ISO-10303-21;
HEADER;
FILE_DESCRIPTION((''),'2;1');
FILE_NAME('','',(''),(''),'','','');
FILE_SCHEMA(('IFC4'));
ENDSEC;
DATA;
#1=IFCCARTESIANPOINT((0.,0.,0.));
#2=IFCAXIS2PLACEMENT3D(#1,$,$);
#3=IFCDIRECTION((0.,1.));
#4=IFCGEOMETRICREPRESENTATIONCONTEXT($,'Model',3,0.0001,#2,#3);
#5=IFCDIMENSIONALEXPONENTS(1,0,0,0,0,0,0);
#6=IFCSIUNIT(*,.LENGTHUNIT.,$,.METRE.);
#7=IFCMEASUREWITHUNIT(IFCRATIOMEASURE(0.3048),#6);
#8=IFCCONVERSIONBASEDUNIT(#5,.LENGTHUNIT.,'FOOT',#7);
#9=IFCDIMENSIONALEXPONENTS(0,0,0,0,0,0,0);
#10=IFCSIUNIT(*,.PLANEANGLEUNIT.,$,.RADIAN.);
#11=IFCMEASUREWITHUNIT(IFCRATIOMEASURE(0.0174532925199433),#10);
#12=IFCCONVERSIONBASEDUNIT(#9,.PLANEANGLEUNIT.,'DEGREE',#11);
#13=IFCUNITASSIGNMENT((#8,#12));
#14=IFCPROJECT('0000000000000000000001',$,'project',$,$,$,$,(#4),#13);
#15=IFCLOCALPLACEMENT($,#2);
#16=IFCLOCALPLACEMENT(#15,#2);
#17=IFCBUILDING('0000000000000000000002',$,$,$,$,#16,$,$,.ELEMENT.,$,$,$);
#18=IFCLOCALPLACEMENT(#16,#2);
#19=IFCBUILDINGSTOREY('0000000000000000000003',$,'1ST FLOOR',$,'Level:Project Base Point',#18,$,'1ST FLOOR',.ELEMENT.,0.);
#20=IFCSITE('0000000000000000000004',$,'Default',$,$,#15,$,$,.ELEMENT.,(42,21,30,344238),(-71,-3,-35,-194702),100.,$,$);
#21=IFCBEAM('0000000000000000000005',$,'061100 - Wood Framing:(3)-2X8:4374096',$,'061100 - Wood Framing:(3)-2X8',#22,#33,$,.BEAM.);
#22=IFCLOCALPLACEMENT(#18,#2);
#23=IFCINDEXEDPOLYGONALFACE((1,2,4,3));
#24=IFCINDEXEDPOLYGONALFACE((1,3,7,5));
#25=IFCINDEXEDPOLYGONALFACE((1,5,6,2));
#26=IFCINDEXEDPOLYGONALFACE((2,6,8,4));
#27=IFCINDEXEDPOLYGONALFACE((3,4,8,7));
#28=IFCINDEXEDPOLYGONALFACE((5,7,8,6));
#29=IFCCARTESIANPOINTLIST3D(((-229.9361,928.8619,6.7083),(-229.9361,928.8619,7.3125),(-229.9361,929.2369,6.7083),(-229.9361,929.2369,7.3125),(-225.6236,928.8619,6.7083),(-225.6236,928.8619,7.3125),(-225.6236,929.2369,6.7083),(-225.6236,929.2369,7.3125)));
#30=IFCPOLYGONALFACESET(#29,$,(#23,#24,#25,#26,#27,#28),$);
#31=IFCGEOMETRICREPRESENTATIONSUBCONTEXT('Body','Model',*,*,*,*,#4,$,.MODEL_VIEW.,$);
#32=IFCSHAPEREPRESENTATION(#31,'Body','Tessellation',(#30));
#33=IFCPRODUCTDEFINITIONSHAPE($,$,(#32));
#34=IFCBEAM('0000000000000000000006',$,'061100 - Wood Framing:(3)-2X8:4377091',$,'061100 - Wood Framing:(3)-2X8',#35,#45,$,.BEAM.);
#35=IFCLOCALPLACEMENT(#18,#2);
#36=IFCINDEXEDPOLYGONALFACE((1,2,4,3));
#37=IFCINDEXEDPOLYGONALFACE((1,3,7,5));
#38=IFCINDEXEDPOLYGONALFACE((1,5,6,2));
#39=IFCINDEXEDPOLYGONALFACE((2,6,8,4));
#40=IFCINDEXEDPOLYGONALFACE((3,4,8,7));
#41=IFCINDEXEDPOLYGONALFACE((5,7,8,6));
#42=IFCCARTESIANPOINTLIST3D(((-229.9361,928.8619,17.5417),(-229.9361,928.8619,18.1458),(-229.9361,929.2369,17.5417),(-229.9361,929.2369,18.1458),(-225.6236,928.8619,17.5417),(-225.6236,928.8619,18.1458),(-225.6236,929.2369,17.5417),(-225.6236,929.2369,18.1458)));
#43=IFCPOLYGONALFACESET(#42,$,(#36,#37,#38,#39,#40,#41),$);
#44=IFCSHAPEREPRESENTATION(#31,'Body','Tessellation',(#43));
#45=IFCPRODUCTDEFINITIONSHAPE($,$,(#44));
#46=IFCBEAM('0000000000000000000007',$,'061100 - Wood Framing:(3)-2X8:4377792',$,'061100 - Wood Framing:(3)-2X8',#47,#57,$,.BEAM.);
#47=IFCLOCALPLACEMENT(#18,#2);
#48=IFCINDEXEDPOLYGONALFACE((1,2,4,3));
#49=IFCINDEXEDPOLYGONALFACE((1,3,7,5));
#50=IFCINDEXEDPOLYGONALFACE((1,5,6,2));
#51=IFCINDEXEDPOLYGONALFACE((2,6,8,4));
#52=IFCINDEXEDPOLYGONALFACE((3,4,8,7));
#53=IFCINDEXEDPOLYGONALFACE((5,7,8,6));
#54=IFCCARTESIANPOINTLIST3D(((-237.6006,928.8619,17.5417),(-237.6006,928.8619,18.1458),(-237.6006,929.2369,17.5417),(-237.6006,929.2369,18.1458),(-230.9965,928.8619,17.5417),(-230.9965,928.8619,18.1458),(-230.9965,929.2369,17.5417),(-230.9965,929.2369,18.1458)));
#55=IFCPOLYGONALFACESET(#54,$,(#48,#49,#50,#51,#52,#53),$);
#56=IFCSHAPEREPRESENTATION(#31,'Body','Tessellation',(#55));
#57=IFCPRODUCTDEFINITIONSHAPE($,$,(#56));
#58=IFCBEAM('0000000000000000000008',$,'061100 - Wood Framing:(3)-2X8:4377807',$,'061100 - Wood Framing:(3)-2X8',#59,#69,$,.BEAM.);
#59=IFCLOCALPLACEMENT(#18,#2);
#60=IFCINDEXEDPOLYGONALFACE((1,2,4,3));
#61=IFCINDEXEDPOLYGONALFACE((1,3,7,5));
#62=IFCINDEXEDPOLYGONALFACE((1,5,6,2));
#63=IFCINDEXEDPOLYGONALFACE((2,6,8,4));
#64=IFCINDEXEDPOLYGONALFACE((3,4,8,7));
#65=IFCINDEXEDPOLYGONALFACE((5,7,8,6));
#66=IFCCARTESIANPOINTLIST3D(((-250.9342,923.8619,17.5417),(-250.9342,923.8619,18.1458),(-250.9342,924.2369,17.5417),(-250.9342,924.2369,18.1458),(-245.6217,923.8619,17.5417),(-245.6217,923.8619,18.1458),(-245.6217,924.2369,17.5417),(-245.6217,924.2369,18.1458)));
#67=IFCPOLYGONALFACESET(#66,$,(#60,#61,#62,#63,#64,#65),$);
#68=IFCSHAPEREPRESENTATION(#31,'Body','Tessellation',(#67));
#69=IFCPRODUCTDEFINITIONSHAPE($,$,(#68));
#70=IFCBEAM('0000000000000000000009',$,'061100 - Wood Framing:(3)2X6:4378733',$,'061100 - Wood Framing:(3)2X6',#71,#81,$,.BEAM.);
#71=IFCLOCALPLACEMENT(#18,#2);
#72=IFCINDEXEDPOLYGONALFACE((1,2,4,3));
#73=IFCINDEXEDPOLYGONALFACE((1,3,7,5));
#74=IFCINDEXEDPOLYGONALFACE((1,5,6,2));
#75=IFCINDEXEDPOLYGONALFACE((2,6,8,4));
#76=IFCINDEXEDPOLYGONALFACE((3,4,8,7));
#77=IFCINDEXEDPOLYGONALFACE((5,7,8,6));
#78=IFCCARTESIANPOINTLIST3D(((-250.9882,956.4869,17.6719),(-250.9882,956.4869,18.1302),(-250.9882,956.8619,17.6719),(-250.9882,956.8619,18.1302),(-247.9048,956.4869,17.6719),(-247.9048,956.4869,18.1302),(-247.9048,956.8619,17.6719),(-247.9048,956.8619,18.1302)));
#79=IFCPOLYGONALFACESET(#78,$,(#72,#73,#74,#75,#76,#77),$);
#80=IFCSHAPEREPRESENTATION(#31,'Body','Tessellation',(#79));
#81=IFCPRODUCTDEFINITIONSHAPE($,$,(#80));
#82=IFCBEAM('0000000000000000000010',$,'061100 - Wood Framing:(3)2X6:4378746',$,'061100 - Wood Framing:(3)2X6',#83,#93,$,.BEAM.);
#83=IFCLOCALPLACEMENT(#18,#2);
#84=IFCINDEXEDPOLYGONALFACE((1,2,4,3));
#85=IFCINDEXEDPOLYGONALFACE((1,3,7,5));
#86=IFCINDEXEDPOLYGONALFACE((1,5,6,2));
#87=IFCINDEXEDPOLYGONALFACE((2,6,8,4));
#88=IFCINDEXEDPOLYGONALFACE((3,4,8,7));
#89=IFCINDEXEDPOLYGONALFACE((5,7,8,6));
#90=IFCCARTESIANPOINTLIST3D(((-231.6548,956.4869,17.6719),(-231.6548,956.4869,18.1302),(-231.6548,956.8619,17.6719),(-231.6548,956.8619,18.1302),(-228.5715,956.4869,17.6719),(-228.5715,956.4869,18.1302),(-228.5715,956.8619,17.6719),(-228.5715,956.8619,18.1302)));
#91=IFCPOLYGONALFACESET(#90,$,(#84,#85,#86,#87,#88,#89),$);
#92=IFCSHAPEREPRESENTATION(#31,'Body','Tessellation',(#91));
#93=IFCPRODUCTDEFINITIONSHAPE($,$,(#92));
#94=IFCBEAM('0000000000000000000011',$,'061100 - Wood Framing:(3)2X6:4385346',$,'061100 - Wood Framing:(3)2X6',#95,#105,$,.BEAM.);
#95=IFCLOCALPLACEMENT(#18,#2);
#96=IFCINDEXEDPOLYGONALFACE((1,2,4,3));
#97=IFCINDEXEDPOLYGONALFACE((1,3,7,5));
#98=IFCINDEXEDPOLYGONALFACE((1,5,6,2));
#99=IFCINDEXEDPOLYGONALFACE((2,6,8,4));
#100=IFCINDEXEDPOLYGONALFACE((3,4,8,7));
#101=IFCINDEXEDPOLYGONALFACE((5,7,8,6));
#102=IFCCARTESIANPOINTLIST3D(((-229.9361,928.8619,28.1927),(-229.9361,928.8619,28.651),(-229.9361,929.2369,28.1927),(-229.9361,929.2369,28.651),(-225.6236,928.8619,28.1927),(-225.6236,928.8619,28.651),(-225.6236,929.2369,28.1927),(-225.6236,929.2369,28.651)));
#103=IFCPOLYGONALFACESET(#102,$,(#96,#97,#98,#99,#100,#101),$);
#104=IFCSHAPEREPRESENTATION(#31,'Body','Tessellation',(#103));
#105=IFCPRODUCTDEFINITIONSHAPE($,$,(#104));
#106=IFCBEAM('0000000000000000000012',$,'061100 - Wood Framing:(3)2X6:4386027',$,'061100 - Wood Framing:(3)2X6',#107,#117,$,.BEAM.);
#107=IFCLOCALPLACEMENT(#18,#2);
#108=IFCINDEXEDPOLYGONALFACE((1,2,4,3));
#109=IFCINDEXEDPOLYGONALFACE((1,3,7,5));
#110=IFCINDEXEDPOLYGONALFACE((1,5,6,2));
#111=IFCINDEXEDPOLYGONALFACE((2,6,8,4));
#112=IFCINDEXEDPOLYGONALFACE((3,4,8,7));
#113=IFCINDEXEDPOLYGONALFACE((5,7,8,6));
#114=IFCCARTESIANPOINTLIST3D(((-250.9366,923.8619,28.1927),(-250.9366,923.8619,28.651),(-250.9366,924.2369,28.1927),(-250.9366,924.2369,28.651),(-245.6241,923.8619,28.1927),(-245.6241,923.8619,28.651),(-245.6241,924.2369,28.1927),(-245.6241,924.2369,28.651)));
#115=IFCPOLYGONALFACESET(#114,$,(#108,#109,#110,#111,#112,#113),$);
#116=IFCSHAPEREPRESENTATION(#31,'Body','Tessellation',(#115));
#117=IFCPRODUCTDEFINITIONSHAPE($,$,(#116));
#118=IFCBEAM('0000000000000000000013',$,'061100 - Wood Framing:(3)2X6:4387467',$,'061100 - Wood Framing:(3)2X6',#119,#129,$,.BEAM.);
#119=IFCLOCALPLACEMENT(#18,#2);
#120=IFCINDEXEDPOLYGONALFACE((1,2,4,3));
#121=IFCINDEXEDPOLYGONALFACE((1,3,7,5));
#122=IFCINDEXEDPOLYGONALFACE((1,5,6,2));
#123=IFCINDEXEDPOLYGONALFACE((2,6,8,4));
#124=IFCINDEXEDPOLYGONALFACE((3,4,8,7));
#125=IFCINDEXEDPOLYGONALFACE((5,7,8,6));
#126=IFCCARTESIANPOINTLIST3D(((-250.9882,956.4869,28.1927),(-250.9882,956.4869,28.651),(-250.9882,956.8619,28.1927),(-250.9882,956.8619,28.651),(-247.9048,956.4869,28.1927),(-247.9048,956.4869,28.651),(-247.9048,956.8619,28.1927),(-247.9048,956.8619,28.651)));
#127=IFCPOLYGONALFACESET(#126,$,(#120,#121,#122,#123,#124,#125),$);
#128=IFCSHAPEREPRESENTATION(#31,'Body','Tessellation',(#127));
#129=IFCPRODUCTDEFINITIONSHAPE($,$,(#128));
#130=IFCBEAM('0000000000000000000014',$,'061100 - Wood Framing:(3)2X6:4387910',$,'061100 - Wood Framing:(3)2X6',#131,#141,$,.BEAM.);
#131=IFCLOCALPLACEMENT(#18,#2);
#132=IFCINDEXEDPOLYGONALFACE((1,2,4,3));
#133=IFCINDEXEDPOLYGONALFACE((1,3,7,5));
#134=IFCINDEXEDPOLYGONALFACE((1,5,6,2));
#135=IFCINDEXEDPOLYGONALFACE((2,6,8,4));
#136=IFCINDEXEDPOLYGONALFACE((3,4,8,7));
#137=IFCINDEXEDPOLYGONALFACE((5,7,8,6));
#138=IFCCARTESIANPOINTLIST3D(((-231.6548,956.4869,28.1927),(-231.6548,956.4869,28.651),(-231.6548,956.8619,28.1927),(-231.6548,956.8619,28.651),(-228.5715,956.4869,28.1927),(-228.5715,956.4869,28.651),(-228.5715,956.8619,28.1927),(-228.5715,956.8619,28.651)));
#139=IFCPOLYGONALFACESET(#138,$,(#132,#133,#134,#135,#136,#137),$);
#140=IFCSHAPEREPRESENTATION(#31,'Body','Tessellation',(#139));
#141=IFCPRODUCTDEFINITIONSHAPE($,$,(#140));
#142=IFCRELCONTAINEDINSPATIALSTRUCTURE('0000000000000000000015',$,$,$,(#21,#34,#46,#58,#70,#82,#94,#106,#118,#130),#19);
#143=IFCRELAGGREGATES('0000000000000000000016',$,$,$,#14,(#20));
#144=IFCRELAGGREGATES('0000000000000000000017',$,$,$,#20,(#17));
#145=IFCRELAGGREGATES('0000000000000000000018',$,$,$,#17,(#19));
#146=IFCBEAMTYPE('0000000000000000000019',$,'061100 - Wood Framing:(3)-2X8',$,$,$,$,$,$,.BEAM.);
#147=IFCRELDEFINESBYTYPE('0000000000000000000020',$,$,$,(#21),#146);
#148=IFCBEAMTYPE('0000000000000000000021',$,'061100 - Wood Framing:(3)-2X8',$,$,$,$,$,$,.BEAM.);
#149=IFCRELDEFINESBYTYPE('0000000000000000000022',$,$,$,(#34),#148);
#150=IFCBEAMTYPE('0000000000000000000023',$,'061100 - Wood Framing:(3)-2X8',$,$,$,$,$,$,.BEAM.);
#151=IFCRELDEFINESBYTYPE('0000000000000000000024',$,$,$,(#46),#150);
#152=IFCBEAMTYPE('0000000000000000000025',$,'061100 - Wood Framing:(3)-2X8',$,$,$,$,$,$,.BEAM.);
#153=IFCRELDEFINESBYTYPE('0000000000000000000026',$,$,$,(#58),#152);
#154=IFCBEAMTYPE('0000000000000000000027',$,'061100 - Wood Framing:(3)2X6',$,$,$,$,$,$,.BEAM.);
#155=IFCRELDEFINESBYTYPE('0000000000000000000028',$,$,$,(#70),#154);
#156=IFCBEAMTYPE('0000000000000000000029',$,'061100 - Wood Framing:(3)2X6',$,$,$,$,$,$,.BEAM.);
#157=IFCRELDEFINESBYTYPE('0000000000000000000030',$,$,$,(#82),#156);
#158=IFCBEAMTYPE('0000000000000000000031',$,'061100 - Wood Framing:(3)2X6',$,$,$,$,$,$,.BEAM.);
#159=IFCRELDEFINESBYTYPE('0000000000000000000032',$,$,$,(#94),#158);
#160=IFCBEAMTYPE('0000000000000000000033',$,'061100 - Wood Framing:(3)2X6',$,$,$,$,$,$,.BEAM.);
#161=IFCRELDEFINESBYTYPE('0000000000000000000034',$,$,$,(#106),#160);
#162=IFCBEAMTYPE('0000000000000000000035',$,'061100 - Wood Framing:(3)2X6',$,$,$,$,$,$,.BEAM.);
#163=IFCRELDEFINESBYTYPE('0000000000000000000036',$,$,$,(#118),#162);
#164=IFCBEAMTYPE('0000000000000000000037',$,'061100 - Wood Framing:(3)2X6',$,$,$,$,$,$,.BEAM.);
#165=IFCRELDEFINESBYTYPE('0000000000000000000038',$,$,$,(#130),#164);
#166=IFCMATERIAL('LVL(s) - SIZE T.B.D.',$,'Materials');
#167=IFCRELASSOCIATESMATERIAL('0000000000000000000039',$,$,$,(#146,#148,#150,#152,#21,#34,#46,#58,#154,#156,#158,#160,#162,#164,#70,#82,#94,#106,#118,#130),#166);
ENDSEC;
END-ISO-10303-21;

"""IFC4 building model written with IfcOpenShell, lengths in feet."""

from ifc_helpers import new_model, entity, si_unit, converted_unit, direction, frame, frame_2d, origin, place, context, subcontext, project, spatial, rectangle, extrude, source, transform, mapped, material, material_profile, profile_set, profile_usage, type_object, type_shapes, element, save


model = new_model("IFC4")

# Units and contexts
model_context = context("Model", 3, precision=0.0001, world=origin(), true_north=direction((0.0, 1.0)))
body_context = subcontext(model_context, "Body", "Model", "MODEL_VIEW")
ifc_project = project(units=[converted_unit("LENGTHUNIT", "FOOT", entity("IfcRatioMeasure", 0.3048), si_unit("LENGTHUNIT", "METRE"), dimensions=[1, 0, 0, 0, 0, 0, 0]), converted_unit("PLANEANGLEUNIT", "DEGREE", entity("IfcRatioMeasure", 0.0174532925199433), si_unit("PLANEANGLEUNIT", "RADIAN"), dimensions=[0, 0, 0, 0, 0, 0, 0])], contexts=[model_context])

# Site, building, storey
site_placement = place(None, origin())
site = spatial("IfcSite", under=ifc_project, at=site_placement, Name="Default", CompositionType="ELEMENT", RefLatitude=(42, 21, 30, 344238), RefLongitude=(-71, -3, -35, -194702), RefElevation=100.0)
building_placement = place(site_placement, origin())
building = spatial("IfcBuilding", under=site, at=building_placement, CompositionType="ELEMENT")
storey_placement = place(building_placement, origin())
storey = spatial("IfcBuildingStorey", under=building, at=storey_placement, Name="1ST FLOOR", ObjectType="Level:Project Base Point", LongName="1ST FLOOR", CompositionType="ELEMENT", Elevation=0.0)

# Beams
ifc_material_1 = material(Name="LVL(s) - SIZE T.B.D.", Category="Materials")
ifc_material_profile_1 = material_profile(ifc_material_1, rectangle(XDim=0.6042, YDim=0.375, at=frame_2d((0.0, 0.0), x_axis=(1.0, 0.0))), Name="(3)-2X8")
ifc_profile_set_1 = profile_set([ifc_material_profile_1], Name="(3)-2X8")
ifc_profile_usage_1 = profile_usage(ifc_profile_set_1, cardinal=8)
beam_type_1 = type_object("IfcBeamType", Name="061100 - Wood Framing:(3)-2X8", PredefinedType="BEAM", material=ifc_profile_set_1)
shared_shape_1 = source(origin(), body_context, "Body", "SweptSolid", [
    extrude(rectangle(XDim=0.6042, YDim=0.375, at=frame_2d((0.0, 0.0), x_axis=(1.0, 0.0))), frame((-2.1737, 0.0, 0.0), z_axis=(1.0, 0.0, 0.0), x_axis=(0.0, 0.0, -1.0)), (0.0, 0.0, 1.0), 4.3125),
])
type_shapes(beam_type_1, [shared_shape_1])
beam_1_placement = place(storey_placement, frame((-227.7624, 929.0494, 7.0104)))
element("IfcBeam", 1, at=beam_1_placement, inside=storey, type_object=beam_type_1, material=ifc_profile_usage_1, Name="061100 - Wood Framing:(3)-2X8:4374096", ObjectType="061100 - Wood Framing:(3)-2X8", PredefinedType="BEAM", context=body_context, shape_type="MappedRepresentation", body=[
    mapped(shared_shape_1, transform((0.0, 0.0, 0.0), scale=1.0)),
])
ifc_profile_usage_2 = profile_usage(ifc_profile_set_1, cardinal=8)
beam_type_2 = type_object("IfcBeamType", Name="061100 - Wood Framing:(3)-2X8", PredefinedType="BEAM", material=ifc_profile_set_1)
shared_shape_2 = source(origin(), body_context, "Body", "SweptSolid", [
    extrude(rectangle(XDim=0.6042, YDim=0.375, at=frame_2d((0.0, 0.0), x_axis=(1.0, 0.0))), frame((-2.18, 0.0, 0.0), z_axis=(1.0, 0.0, 0.0), x_axis=(0.0, 0.0, -1.0)), (0.0, 0.0, 1.0), 4.3125),
])
type_shapes(beam_type_2, [shared_shape_2])
beam_2_placement = place(storey_placement, frame((-227.7561, 929.0494, 17.8438)))
element("IfcBeam", 2, at=beam_2_placement, inside=storey, type_object=beam_type_2, material=ifc_profile_usage_2, Name="061100 - Wood Framing:(3)-2X8:4377091", ObjectType="061100 - Wood Framing:(3)-2X8", PredefinedType="BEAM", context=body_context, shape_type="MappedRepresentation", body=[
    mapped(shared_shape_2, transform((0.0, 0.0, 0.0), scale=1.0)),
])
ifc_profile_usage_3 = profile_usage(ifc_profile_set_1, cardinal=8)
beam_type_3 = type_object("IfcBeamType", Name="061100 - Wood Framing:(3)-2X8", PredefinedType="BEAM", material=ifc_profile_set_1)
shared_shape_3 = source(origin(), body_context, "Body", "SweptSolid", [
    extrude(rectangle(XDim=0.6042, YDim=0.375, at=frame_2d((0.0, 0.0), x_axis=(1.0, 0.0))), frame((-3.3258, 0.0, 0.0), z_axis=(1.0, 0.0, 0.0), x_axis=(0.0, 0.0, -1.0)), (0.0, 0.0, 1.0), 6.6042),
])
type_shapes(beam_type_3, [shared_shape_3])
beam_3_placement = place(storey_placement, frame((-234.2748, 929.0494, 17.8438)))
element("IfcBeam", 3, at=beam_3_placement, inside=storey, type_object=beam_type_3, material=ifc_profile_usage_3, Name="061100 - Wood Framing:(3)-2X8:4377792", ObjectType="061100 - Wood Framing:(3)-2X8", PredefinedType="BEAM", context=body_context, shape_type="MappedRepresentation", body=[
    mapped(shared_shape_3, transform((0.0, 0.0, 0.0), scale=1.0)),
])
ifc_profile_usage_4 = profile_usage(ifc_profile_set_1, cardinal=8)
beam_type_4 = type_object("IfcBeamType", Name="061100 - Wood Framing:(3)-2X8", PredefinedType="BEAM", material=ifc_profile_set_1)
shared_shape_4 = source(origin(), body_context, "Body", "SweptSolid", [
    extrude(rectangle(XDim=0.6042, YDim=0.375, at=frame_2d((0.0, 0.0), x_axis=(1.0, 0.0))), frame((-2.68, 0.0, 0.0), z_axis=(1.0, 0.0, 0.0), x_axis=(0.0, 0.0, -1.0)), (0.0, 0.0, 1.0), 5.3125),
])
type_shapes(beam_type_4, [shared_shape_4])
beam_4_placement = place(storey_placement, frame((-248.2542, 924.0494, 17.8438)))
element("IfcBeam", 4, at=beam_4_placement, inside=storey, type_object=beam_type_4, material=ifc_profile_usage_4, Name="061100 - Wood Framing:(3)-2X8:4377807", ObjectType="061100 - Wood Framing:(3)-2X8", PredefinedType="BEAM", context=body_context, shape_type="MappedRepresentation", body=[
    mapped(shared_shape_4, transform((0.0, 0.0, 0.0), scale=1.0)),
])
ifc_material_profile_2 = material_profile(ifc_material_1, rectangle(XDim=0.4583, YDim=0.375, at=frame_2d((0.0, 0.0), x_axis=(1.0, 0.0))), Name="(3)2X6")
ifc_profile_set_2 = profile_set([ifc_material_profile_2], Name="(3)2X6")
ifc_profile_usage_5 = profile_usage(ifc_profile_set_2, cardinal=8)
beam_type_5 = type_object("IfcBeamType", Name="061100 - Wood Framing:(3)2X6", PredefinedType="BEAM", material=ifc_profile_set_2)
shared_shape_5 = source(origin(), body_context, "Body", "SweptSolid", [
    extrude(rectangle(XDim=0.4583, YDim=0.375, at=frame_2d((0.0, 0.0), x_axis=(1.0, 0.0))), frame((-1.5364, 0.0, 0.0), z_axis=(1.0, 0.0, 0.0), x_axis=(0.0, 0.0, -1.0)), (0.0, 0.0, 1.0), 3.0833),
])
type_shapes(beam_type_5, [shared_shape_5])
beam_5_placement = place(storey_placement, frame((-249.4517, 956.6744, 17.901)))
element("IfcBeam", 5, at=beam_5_placement, inside=storey, type_object=beam_type_5, material=ifc_profile_usage_5, Name="061100 - Wood Framing:(3)2X6:4378733", ObjectType="061100 - Wood Framing:(3)2X6", PredefinedType="BEAM", context=body_context, shape_type="MappedRepresentation", body=[
    mapped(shared_shape_5, transform((0.0, 0.0, 0.0), scale=1.0)),
])
ifc_profile_usage_6 = profile_usage(ifc_profile_set_2, cardinal=8)
beam_type_6 = type_object("IfcBeamType", Name="061100 - Wood Framing:(3)2X6", PredefinedType="BEAM", material=ifc_profile_set_2)
shared_shape_6 = source(origin(), body_context, "Body", "SweptSolid", [
    extrude(rectangle(XDim=0.4583, YDim=0.375, at=frame_2d((0.0, 0.0), x_axis=(1.0, 0.0))), frame((-1.5156, 0.0, 0.0), z_axis=(1.0, 0.0, 0.0), x_axis=(0.0, 0.0, -1.0)), (0.0, 0.0, 1.0), 3.0833),
])
type_shapes(beam_type_6, [shared_shape_6])
beam_6_placement = place(storey_placement, frame((-230.1392, 956.6744, 17.901)))
element("IfcBeam", 6, at=beam_6_placement, inside=storey, type_object=beam_type_6, material=ifc_profile_usage_6, Name="061100 - Wood Framing:(3)2X6:4378746", ObjectType="061100 - Wood Framing:(3)2X6", PredefinedType="BEAM", context=body_context, shape_type="MappedRepresentation", body=[
    mapped(shared_shape_6, transform((0.0, 0.0, 0.0), scale=1.0)),
])
ifc_profile_usage_7 = profile_usage(ifc_profile_set_2, cardinal=8)
beam_type_7 = type_object("IfcBeamType", Name="061100 - Wood Framing:(3)2X6", PredefinedType="BEAM", material=ifc_profile_set_2)
shared_shape_7 = source(origin(), body_context, "Body", "SweptSolid", [
    extrude(rectangle(XDim=0.4583, YDim=0.375, at=frame_2d((0.0, 0.0), x_axis=(1.0, 0.0))), frame((-2.1711, 0.0, 0.0), z_axis=(1.0, 0.0, 0.0), x_axis=(0.0, 0.0, -1.0)), (0.0, 0.0, 1.0), 4.3125),
])
type_shapes(beam_type_7, [shared_shape_7])
beam_7_placement = place(storey_placement, frame((-227.7649, 929.0494, 28.4219)))
element("IfcBeam", 7, at=beam_7_placement, inside=storey, type_object=beam_type_7, material=ifc_profile_usage_7, Name="061100 - Wood Framing:(3)2X6:4385346", ObjectType="061100 - Wood Framing:(3)2X6", PredefinedType="BEAM", context=body_context, shape_type="MappedRepresentation", body=[
    mapped(shared_shape_7, transform((0.0, 0.0, 0.0), scale=1.0)),
])
ifc_profile_usage_8 = profile_usage(ifc_profile_set_2, cardinal=8)
beam_type_8 = type_object("IfcBeamType", Name="061100 - Wood Framing:(3)2X6", PredefinedType="BEAM", material=ifc_profile_set_2)
shared_shape_8 = source(origin(), body_context, "Body", "SweptSolid", [
    extrude(rectangle(XDim=0.4583, YDim=0.375, at=frame_2d((0.0, 0.0), x_axis=(1.0, 0.0))), frame((-2.6711, 0.0, 0.0), z_axis=(1.0, 0.0, 0.0), x_axis=(0.0, 0.0, -1.0)), (0.0, 0.0, 1.0), 5.3125),
])
type_shapes(beam_type_8, [shared_shape_8])
beam_8_placement = place(storey_placement, frame((-248.2654, 924.0494, 28.4219)))
element("IfcBeam", 8, at=beam_8_placement, inside=storey, type_object=beam_type_8, material=ifc_profile_usage_8, Name="061100 - Wood Framing:(3)2X6:4386027", ObjectType="061100 - Wood Framing:(3)2X6", PredefinedType="BEAM", context=body_context, shape_type="MappedRepresentation", body=[
    mapped(shared_shape_8, transform((0.0, 0.0, 0.0), scale=1.0)),
])
ifc_profile_usage_9 = profile_usage(ifc_profile_set_2, cardinal=8)
beam_type_9 = type_object("IfcBeamType", Name="061100 - Wood Framing:(3)2X6", PredefinedType="BEAM", material=ifc_profile_set_2)
shared_shape_9 = source(origin(), body_context, "Body", "SweptSolid", [
    extrude(rectangle(XDim=0.4583, YDim=0.375, at=frame_2d((0.0, 0.0), x_axis=(1.0, 0.0))), frame((-1.5391, 0.0, 0.0), z_axis=(1.0, 0.0, 0.0), x_axis=(0.0, 0.0, -1.0)), (0.0, 0.0, 1.0), 3.0833),
])
type_shapes(beam_type_9, [shared_shape_9])
beam_9_placement = place(storey_placement, frame((-249.4491, 956.6744, 28.4219)))
element("IfcBeam", 9, at=beam_9_placement, inside=storey, type_object=beam_type_9, material=ifc_profile_usage_9, Name="061100 - Wood Framing:(3)2X6:4387467", ObjectType="061100 - Wood Framing:(3)2X6", PredefinedType="BEAM", context=body_context, shape_type="MappedRepresentation", body=[
    mapped(shared_shape_9, transform((0.0, 0.0, 0.0), scale=1.0)),
])
ifc_profile_usage_10 = profile_usage(ifc_profile_set_2, cardinal=8)
beam_type_10 = type_object("IfcBeamType", Name="061100 - Wood Framing:(3)2X6", PredefinedType="BEAM", material=ifc_profile_set_2)
shared_shape_10 = source(origin(), body_context, "Body", "SweptSolid", [
    extrude(rectangle(XDim=0.4583, YDim=0.375, at=frame_2d((0.0, 0.0), x_axis=(1.0, 0.0))), frame((-1.5639, 0.0, 0.0), z_axis=(1.0, 0.0, 0.0), x_axis=(0.0, 0.0, -1.0)), (0.0, 0.0, 1.0), 3.0833),
])
type_shapes(beam_type_10, [shared_shape_10])
beam_10_placement = place(storey_placement, frame((-230.091, 956.6744, 28.4219)))
element("IfcBeam", 10, at=beam_10_placement, inside=storey, type_object=beam_type_10, material=ifc_profile_usage_10, Name="061100 - Wood Framing:(3)2X6:4387910", ObjectType="061100 - Wood Framing:(3)2X6", PredefinedType="BEAM", context=body_context, shape_type="MappedRepresentation", body=[
    mapped(shared_shape_10, transform((0.0, 0.0, 0.0), scale=1.0)),
])

save(model, "model.ifc")
